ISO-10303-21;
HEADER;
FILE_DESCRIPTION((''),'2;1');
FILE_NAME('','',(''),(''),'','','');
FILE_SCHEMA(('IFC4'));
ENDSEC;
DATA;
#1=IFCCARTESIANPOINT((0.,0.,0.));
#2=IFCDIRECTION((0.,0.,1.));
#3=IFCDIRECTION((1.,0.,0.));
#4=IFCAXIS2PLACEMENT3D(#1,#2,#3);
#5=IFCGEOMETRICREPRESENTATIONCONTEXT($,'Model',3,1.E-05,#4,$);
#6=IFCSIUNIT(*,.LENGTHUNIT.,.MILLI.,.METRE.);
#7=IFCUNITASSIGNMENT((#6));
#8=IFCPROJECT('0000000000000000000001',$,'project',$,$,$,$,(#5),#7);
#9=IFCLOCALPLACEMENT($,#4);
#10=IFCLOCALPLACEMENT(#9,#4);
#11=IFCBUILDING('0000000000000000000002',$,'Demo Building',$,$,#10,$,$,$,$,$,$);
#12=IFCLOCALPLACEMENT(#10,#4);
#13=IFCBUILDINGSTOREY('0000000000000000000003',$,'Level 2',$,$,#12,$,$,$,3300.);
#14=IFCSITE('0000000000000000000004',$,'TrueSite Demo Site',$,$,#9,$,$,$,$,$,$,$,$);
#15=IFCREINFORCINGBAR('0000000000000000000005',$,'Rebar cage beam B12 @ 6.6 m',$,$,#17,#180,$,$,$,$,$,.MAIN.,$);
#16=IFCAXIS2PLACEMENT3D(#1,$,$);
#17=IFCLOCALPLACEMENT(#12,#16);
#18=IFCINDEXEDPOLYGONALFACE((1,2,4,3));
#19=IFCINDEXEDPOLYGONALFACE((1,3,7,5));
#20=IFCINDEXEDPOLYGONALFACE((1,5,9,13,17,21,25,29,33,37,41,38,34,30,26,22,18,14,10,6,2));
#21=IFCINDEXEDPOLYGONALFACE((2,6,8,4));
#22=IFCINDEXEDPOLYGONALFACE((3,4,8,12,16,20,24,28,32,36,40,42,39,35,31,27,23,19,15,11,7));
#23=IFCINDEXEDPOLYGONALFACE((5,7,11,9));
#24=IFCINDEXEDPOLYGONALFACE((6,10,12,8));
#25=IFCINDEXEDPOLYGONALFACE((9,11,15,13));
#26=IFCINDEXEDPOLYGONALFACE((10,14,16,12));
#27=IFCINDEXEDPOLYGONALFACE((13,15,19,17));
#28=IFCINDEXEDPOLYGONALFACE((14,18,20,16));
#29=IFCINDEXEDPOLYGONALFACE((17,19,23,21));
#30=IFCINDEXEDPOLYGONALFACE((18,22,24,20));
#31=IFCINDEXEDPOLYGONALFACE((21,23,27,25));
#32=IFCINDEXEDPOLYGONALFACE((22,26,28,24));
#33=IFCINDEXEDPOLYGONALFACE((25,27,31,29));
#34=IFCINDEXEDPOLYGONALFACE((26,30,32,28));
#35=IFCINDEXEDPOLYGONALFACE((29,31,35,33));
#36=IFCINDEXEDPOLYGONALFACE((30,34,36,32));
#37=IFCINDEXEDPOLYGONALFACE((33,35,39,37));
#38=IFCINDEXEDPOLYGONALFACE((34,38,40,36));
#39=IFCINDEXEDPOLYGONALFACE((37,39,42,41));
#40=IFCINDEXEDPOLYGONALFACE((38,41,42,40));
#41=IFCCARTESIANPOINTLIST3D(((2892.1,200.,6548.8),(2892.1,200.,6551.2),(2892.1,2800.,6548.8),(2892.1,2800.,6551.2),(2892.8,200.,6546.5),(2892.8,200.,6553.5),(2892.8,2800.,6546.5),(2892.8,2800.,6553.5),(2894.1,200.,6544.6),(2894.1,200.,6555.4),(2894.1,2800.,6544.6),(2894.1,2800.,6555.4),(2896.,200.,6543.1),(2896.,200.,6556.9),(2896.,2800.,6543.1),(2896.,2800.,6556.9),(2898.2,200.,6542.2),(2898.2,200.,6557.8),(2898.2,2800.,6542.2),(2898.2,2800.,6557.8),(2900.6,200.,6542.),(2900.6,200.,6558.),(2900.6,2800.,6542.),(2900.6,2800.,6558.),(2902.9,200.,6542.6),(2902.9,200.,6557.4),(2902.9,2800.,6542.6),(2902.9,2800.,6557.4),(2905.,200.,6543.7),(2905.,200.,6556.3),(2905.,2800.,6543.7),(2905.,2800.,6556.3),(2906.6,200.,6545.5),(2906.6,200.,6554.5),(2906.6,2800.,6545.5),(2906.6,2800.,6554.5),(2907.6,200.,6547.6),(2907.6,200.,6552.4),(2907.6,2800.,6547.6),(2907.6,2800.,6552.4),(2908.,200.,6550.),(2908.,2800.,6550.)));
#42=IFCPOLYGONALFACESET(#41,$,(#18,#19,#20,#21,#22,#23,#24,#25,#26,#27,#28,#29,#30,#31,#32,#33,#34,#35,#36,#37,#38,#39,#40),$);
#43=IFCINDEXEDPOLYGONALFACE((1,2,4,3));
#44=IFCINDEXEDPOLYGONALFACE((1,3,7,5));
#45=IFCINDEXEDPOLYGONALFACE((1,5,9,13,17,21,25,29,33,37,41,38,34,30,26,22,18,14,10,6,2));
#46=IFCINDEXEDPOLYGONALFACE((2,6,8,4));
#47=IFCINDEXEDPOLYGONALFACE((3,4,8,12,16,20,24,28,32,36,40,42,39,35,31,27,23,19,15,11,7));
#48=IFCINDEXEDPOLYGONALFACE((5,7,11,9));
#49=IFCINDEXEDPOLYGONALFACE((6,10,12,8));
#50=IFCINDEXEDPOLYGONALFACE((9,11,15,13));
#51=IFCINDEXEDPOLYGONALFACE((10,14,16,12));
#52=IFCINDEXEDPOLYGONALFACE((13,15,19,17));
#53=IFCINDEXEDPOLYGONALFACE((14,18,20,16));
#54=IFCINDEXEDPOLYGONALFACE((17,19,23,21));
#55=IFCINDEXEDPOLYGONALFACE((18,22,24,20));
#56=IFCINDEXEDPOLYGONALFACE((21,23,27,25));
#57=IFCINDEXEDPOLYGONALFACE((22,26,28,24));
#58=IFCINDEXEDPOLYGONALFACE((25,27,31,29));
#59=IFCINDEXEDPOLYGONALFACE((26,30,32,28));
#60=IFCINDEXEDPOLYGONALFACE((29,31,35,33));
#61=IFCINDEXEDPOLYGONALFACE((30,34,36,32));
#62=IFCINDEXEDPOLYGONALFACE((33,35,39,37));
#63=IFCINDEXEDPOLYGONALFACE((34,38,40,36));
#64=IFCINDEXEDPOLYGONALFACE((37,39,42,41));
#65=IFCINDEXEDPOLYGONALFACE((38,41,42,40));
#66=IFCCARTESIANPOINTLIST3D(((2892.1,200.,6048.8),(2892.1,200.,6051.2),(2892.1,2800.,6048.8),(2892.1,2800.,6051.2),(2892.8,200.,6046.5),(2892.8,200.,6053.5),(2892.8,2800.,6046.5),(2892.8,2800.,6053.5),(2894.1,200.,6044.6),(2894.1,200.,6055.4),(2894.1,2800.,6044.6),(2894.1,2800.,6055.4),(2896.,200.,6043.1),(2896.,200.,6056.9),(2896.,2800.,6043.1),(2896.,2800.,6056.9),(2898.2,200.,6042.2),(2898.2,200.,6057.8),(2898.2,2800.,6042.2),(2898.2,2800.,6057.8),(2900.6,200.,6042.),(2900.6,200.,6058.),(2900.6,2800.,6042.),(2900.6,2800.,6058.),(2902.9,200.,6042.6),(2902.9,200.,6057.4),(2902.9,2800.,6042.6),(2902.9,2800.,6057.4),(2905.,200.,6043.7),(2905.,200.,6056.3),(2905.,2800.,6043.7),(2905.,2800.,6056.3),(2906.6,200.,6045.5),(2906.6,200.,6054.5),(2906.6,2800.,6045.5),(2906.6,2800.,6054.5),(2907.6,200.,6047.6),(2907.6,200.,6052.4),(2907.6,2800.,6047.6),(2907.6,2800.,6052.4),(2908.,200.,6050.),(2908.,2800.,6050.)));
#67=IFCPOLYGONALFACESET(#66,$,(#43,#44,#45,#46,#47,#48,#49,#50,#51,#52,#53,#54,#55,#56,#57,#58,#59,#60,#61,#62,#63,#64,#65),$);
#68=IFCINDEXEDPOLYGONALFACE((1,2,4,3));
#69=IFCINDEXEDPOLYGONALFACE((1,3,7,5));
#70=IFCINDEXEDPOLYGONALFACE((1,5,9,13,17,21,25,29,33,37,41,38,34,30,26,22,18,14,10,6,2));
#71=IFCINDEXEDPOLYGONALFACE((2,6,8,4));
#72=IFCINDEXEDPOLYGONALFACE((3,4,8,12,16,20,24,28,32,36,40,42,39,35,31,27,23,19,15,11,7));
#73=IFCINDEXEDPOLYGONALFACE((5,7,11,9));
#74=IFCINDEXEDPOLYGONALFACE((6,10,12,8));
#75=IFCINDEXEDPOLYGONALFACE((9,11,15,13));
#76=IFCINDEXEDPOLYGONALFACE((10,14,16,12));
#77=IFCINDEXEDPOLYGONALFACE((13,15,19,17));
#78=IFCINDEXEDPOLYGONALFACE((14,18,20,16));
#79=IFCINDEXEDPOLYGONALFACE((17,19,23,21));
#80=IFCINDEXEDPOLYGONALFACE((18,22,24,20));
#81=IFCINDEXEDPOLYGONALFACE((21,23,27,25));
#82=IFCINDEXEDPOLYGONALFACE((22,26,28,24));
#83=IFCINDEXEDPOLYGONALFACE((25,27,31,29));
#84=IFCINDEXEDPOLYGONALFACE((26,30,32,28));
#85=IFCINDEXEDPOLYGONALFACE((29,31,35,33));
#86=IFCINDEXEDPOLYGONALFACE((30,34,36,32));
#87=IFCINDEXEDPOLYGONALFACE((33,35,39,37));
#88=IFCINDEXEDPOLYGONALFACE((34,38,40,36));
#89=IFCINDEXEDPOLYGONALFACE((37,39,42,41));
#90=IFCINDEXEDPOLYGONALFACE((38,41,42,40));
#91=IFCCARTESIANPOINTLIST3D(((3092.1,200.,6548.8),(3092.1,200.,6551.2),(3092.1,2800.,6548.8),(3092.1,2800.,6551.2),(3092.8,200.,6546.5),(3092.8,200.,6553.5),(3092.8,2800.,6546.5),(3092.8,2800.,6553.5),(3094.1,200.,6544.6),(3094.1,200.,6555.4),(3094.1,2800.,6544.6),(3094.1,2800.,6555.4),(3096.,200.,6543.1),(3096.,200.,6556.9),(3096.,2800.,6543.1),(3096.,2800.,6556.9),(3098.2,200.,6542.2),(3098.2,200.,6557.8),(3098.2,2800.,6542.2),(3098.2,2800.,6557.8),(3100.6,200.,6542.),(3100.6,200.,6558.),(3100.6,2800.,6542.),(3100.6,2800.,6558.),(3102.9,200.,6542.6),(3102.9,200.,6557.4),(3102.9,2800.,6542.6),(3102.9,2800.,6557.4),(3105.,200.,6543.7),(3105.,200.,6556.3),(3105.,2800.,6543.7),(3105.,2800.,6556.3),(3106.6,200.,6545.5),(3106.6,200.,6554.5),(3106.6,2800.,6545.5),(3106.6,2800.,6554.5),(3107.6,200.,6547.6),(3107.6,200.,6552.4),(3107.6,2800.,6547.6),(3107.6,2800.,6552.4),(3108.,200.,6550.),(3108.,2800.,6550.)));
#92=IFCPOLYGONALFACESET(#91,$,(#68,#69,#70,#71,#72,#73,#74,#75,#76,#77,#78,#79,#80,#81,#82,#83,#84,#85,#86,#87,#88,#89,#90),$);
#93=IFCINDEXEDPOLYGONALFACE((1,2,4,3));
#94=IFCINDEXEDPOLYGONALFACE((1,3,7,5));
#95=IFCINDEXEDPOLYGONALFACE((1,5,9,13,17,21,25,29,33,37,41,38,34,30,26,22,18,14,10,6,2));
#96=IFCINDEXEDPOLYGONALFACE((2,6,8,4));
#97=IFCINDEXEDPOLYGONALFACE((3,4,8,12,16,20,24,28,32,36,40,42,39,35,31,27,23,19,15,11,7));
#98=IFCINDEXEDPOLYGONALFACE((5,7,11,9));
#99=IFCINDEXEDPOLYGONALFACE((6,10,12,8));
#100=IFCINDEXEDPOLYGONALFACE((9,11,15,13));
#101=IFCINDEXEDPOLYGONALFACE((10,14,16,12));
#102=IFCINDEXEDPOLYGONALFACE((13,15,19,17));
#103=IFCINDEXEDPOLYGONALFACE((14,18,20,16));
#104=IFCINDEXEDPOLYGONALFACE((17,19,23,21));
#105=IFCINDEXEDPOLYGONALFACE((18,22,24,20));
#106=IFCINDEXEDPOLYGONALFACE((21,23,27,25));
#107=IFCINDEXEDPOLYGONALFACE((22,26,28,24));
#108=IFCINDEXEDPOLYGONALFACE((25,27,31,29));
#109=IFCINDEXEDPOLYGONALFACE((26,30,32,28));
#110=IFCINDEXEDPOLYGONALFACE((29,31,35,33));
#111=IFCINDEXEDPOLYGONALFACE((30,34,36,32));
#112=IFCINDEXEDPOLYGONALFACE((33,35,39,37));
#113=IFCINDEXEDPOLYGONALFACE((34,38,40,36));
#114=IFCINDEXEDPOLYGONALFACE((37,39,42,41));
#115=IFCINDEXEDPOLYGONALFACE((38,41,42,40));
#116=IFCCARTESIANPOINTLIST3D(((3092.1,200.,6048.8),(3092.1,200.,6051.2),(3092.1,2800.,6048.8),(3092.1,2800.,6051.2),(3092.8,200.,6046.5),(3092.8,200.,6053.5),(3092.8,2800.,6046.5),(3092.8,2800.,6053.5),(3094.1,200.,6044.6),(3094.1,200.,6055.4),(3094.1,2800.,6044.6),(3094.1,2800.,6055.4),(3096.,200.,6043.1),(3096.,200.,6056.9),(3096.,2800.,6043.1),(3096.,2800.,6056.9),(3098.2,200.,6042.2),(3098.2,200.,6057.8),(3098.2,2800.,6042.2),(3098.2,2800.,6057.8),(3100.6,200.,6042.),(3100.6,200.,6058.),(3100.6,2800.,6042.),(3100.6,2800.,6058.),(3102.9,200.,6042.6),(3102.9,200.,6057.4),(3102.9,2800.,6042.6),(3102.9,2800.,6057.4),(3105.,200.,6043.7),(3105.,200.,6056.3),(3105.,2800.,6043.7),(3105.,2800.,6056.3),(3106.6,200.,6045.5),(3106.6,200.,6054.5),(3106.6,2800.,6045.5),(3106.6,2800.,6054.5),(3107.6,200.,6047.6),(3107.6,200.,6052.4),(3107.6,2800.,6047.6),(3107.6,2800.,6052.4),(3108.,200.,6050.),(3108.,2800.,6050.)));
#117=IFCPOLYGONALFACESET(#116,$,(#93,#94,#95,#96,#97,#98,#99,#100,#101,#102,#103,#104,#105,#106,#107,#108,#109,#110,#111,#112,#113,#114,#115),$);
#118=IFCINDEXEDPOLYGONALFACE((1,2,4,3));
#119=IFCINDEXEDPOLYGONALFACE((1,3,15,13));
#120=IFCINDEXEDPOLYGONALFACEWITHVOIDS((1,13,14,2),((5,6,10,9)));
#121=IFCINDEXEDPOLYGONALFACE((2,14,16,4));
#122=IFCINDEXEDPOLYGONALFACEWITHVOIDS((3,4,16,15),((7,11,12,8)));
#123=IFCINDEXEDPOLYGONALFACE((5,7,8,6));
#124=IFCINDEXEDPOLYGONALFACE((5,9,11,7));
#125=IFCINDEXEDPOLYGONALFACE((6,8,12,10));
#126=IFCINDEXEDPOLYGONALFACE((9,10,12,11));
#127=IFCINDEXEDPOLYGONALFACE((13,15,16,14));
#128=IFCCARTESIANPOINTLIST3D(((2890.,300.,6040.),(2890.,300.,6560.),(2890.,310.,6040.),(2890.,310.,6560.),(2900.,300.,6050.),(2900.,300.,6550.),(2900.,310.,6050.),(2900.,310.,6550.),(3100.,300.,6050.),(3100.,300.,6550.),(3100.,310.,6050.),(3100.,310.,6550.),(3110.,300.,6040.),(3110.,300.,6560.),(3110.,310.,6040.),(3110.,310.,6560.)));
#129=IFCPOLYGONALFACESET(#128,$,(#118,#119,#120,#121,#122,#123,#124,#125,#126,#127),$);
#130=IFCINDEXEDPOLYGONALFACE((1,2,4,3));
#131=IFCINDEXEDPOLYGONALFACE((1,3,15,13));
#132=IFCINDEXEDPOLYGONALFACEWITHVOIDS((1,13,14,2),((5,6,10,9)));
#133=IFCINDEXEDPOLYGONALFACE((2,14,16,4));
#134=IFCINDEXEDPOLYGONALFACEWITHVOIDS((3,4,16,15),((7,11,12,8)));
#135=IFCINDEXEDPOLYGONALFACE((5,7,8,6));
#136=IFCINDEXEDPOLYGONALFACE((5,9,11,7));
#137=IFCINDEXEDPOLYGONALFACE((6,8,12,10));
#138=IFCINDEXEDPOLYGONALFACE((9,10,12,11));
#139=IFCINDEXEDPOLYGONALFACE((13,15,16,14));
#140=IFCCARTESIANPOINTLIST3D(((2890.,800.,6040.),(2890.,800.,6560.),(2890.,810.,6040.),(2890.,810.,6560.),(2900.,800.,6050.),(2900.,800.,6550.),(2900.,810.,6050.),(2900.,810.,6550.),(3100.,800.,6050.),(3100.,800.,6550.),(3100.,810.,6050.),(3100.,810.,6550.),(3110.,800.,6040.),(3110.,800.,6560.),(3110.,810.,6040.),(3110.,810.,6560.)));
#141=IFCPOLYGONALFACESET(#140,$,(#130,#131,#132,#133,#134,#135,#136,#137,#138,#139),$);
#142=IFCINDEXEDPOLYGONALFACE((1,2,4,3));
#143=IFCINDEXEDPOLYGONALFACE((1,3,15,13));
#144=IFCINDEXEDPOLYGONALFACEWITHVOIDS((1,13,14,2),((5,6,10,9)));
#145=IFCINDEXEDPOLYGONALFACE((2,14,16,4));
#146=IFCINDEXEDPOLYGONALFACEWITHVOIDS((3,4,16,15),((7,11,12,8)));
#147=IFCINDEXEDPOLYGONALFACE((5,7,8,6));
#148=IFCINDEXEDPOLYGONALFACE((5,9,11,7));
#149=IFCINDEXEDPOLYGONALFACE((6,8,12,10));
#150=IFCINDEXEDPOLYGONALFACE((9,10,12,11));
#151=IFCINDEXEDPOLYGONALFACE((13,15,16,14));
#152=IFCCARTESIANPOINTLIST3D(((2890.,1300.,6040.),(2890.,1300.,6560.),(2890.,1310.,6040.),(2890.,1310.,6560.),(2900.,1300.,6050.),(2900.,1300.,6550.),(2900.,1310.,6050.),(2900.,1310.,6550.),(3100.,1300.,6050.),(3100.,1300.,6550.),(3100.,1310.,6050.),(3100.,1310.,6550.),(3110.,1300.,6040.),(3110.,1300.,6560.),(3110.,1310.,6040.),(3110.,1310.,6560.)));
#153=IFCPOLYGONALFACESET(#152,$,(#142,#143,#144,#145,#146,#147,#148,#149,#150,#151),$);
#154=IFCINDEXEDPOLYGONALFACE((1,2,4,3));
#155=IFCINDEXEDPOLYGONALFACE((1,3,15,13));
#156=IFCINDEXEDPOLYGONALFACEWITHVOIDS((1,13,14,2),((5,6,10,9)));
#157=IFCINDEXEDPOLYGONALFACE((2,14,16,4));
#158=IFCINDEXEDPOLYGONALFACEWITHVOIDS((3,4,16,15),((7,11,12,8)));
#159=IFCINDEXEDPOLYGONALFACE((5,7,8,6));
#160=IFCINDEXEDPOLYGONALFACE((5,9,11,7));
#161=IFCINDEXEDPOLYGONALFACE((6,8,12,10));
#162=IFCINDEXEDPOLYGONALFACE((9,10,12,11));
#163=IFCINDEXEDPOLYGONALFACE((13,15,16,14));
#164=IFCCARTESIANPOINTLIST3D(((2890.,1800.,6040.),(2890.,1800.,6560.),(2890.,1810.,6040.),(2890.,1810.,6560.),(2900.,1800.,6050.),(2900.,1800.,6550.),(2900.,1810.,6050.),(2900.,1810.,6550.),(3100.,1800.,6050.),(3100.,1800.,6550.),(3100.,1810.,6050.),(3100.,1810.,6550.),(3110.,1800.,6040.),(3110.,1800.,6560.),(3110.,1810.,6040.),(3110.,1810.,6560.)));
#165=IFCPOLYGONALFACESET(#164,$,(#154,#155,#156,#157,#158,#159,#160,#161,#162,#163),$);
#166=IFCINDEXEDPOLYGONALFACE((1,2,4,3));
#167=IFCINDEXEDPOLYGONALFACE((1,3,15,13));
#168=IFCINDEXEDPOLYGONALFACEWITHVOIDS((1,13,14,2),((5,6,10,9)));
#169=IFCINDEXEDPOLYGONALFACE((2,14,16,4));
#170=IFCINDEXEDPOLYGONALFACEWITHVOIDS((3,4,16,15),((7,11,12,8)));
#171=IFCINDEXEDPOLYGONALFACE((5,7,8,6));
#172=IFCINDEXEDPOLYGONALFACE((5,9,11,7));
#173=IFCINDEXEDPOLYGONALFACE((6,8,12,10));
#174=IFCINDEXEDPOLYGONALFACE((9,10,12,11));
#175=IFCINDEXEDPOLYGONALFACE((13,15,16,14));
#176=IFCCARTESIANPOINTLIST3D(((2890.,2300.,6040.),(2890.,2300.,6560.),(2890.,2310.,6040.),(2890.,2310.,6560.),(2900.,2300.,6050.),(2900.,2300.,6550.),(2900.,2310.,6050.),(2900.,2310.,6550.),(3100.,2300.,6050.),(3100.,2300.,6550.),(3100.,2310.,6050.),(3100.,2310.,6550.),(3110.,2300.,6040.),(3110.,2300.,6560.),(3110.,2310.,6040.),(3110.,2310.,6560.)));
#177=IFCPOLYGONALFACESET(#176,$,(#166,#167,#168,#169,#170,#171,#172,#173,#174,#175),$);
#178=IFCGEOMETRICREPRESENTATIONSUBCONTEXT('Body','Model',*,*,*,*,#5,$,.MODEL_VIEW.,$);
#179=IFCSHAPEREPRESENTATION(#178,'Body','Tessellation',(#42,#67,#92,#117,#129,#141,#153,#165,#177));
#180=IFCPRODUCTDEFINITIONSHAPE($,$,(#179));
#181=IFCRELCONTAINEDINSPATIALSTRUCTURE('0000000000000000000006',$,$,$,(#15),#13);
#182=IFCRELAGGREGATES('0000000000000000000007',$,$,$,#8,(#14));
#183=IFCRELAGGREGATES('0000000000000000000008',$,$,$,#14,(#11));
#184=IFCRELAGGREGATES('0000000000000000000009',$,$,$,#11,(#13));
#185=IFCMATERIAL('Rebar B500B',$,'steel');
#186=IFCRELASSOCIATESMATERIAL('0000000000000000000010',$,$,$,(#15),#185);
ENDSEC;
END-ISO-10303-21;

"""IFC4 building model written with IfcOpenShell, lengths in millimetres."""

from ifc_helpers import new_model, si_unit, frame, origin_with_axes, place, context, subcontext, project, spatial, hollow_rectangle, circle, extrude, material, element, save


model = new_model("IFC4")

# Units and contexts
model_context = context("Model", 3, precision=1e-05, world=origin_with_axes())
body_context = subcontext(model_context, "Body", "Model", "MODEL_VIEW")
ifc_project = project(units=[si_unit("LENGTHUNIT", "METRE", prefix="MILLI")], contexts=[model_context])

# Site, building, storey
site_placement = place(None, origin_with_axes())
site = spatial("IfcSite", under=ifc_project, at=site_placement, Name="TrueSite Demo Site")
building_placement = place(site_placement, origin_with_axes())
building = spatial("IfcBuilding", under=site, at=building_placement, Name="Demo Building")
storey_placement = place(building_placement, origin_with_axes())
storey = spatial("IfcBuildingStorey", under=building, at=storey_placement, Name="Level 2", Elevation=3300.0)

# Reinforcing bar
ifc_material_1 = material(Name="Rebar B500B", Category="steel")
for number, where, z_axis, x_axis, name in (
    (1, (3000.0, 200.0, 6300.0), (0.0, 1.0, 0.0), (1.0, 0.0, 0.0), "Rebar cage beam B12 @ 6.6 m"),
):
    element("IfcReinforcingBar", number, at=place(storey_placement, frame(where, z_axis=z_axis, x_axis=x_axis)), inside=storey, material=ifc_material_1, Name=name, PredefinedType="MAIN", context=body_context, shape_type="SweptSolid", body=[
        extrude(circle(Radius=8.0), frame((-100.0, -250.0, 0.0)), (0.0, 0.0, 1.0), 2600.0),
        extrude(circle(Radius=8.0), frame((-100.0, 250.0, 0.0)), (0.0, 0.0, 1.0), 2600.0),
        extrude(circle(Radius=8.0), frame((100.0, -250.0, 0.0)), (0.0, 0.0, 1.0), 2600.0),
        extrude(circle(Radius=8.0), frame((100.0, 250.0, 0.0)), (0.0, 0.0, 1.0), 2600.0),
        extrude(hollow_rectangle(XDim=220.0, YDim=520.0, WallThickness=10.0), frame((0.0, 0.0, 100.0)), (0.0, 0.0, 1.0), 10.0),
        extrude(hollow_rectangle(XDim=220.0, YDim=520.0, WallThickness=10.0), frame((0.0, 0.0, 600.0)), (0.0, 0.0, 1.0), 10.0),
        extrude(hollow_rectangle(XDim=220.0, YDim=520.0, WallThickness=10.0), frame((0.0, 0.0, 1100.0)), (0.0, 0.0, 1.0), 10.0),
        extrude(hollow_rectangle(XDim=220.0, YDim=520.0, WallThickness=10.0), frame((0.0, 0.0, 1600.0)), (0.0, 0.0, 1.0), 10.0),
        extrude(hollow_rectangle(XDim=220.0, YDim=520.0, WallThickness=10.0), frame((0.0, 0.0, 2100.0)), (0.0, 0.0, 1.0), 10.0),
    ])

save(model, "model.ifc")
